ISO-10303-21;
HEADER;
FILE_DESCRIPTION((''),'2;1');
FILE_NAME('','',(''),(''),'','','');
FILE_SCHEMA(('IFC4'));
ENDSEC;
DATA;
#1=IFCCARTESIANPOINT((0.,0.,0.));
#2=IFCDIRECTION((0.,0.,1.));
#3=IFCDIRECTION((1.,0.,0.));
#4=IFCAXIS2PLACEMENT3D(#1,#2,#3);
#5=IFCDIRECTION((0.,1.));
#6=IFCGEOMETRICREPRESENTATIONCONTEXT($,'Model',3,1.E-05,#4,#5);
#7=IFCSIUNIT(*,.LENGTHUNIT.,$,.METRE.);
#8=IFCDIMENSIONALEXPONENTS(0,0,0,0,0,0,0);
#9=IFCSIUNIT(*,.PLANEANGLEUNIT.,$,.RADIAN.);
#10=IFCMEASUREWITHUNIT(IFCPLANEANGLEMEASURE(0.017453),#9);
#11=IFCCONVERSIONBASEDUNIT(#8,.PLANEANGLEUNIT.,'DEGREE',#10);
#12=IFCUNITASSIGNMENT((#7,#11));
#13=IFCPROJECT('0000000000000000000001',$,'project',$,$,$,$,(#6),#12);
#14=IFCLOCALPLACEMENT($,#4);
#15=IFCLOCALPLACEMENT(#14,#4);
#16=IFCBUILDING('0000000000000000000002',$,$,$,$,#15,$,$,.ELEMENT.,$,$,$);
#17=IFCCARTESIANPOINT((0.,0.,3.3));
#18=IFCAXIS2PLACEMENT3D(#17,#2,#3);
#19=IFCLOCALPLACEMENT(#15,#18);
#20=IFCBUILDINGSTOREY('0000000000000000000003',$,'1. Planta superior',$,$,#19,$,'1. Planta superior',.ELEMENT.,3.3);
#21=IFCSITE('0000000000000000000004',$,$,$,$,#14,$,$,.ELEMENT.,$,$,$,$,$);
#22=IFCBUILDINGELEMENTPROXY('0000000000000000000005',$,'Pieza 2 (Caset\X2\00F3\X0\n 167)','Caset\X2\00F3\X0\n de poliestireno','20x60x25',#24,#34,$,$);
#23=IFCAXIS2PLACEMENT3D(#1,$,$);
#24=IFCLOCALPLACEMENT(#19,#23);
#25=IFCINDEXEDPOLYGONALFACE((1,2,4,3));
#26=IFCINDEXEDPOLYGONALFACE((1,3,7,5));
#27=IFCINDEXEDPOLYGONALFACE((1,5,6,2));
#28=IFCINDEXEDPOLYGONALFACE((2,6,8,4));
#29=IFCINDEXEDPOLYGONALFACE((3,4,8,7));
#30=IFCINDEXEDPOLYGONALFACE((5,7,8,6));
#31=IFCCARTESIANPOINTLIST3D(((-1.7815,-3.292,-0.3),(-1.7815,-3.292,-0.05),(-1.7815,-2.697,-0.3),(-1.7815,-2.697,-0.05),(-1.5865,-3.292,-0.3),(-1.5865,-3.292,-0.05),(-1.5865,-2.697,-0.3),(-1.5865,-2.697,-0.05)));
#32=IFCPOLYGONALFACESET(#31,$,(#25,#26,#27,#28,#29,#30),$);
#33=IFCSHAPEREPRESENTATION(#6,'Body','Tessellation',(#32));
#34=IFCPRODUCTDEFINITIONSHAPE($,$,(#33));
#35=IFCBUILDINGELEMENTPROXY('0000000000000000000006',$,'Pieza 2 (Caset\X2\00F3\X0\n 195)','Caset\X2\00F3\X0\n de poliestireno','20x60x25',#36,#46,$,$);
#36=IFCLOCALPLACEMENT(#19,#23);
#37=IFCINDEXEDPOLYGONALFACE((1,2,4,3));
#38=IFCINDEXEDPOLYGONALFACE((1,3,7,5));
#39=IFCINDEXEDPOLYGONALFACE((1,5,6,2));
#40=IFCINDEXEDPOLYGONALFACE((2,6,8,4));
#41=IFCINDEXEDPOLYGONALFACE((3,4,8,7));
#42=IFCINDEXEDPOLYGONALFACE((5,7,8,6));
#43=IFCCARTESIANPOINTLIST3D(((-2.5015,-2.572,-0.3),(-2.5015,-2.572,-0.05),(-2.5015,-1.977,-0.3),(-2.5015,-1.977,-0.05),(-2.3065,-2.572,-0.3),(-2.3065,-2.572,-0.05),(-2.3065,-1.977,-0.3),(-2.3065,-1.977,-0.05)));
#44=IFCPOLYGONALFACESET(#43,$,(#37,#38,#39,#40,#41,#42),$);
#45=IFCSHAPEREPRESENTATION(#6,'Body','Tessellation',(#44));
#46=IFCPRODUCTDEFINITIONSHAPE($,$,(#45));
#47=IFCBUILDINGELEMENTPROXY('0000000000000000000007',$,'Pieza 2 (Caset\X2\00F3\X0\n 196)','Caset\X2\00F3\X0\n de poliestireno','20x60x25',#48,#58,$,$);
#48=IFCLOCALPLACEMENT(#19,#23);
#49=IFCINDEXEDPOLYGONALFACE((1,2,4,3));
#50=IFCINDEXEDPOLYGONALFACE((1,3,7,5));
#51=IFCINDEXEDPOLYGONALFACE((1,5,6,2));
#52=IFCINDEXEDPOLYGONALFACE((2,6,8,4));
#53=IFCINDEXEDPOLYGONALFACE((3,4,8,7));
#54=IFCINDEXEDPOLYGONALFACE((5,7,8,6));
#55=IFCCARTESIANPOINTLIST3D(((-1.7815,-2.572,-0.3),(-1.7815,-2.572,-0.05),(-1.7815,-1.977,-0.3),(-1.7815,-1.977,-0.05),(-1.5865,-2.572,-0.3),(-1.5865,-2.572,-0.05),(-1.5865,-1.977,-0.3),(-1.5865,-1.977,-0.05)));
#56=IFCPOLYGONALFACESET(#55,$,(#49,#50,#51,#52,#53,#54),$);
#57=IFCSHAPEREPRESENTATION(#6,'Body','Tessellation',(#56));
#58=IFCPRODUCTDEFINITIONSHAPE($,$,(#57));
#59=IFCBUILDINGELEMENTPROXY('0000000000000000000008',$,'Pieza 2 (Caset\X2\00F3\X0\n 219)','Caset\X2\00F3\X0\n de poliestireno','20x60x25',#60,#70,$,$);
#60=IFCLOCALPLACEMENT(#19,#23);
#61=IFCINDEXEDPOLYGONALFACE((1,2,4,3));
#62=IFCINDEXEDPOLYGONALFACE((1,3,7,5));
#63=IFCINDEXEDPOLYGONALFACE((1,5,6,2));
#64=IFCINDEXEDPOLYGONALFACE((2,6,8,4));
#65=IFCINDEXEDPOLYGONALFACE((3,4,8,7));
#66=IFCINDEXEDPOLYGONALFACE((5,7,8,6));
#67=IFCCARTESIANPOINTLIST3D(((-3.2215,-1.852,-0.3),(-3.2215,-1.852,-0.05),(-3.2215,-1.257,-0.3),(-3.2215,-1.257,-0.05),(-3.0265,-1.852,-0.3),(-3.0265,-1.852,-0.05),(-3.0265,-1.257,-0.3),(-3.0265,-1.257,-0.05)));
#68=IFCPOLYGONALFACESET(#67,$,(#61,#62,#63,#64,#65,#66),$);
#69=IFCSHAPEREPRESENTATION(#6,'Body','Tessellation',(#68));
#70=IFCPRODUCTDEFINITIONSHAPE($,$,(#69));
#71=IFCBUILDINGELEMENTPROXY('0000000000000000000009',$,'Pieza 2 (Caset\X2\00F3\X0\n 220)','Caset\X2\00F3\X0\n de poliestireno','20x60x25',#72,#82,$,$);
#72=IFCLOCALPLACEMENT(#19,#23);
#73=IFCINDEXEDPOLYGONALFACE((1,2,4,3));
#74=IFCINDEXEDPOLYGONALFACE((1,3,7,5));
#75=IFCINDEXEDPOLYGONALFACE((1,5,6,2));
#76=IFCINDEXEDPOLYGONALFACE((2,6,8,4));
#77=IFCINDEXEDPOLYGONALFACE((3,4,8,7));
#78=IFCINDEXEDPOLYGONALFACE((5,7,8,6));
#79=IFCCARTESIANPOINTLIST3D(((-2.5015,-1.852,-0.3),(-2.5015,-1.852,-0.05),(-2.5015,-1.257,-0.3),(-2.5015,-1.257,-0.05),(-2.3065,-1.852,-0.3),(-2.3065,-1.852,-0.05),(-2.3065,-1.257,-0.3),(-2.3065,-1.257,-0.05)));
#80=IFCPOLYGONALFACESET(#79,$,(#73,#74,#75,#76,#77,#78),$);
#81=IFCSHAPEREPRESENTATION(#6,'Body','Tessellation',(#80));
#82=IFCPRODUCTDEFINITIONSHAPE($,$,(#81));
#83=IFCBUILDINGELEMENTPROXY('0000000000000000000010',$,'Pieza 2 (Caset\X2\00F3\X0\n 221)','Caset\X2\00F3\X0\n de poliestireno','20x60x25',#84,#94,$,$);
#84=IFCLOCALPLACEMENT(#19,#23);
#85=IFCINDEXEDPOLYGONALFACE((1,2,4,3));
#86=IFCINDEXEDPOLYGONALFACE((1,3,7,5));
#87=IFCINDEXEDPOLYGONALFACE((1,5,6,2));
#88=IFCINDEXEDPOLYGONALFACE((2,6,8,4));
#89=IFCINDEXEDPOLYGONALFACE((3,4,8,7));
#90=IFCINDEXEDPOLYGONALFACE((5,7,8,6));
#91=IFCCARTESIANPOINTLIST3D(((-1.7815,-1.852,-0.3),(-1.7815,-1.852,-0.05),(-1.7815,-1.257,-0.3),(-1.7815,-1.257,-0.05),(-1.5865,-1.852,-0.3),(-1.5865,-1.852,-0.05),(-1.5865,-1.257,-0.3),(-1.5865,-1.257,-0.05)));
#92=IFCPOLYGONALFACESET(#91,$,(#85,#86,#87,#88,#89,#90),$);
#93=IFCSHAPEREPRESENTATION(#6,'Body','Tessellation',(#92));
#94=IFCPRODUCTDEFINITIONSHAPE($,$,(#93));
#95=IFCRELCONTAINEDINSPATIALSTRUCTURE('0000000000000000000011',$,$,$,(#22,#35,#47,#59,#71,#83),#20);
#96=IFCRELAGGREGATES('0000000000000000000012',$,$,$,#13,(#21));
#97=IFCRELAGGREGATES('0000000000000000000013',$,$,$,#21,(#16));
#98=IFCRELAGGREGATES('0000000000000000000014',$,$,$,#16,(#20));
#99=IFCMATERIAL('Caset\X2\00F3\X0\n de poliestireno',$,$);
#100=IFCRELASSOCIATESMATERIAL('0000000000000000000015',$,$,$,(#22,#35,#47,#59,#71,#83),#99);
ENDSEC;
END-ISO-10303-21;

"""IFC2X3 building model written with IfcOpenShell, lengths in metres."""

from ifc_helpers import new_model, entity, si_unit, converted_unit, direction, frame, origin_with_axes, origin_2d_with_axis, place, context, project, spatial, rectangle, extrude, source, transform, mapped, material, element, save


model = new_model("IFC2X3")

# Units and contexts
model_context = context("Model", 3, precision=1e-05, world=origin_with_axes(), true_north=direction((0.0, 1.0)))
ifc_project = project(units=[si_unit("LENGTHUNIT", "METRE"), converted_unit("PLANEANGLEUNIT", "DEGREE", entity("IfcPlaneAngleMeasure", 0.017453), si_unit("PLANEANGLEUNIT", "RADIAN"), dimensions=[0, 0, 0, 0, 0, 0, 0])], contexts=[model_context])

# Site, building, storey
site_placement = place(None, origin_with_axes())
site = spatial("IfcSite", under=ifc_project, at=site_placement, CompositionType="ELEMENT")
building_placement = place(site_placement, origin_with_axes())
building = spatial("IfcBuilding", under=site, at=building_placement, CompositionType="ELEMENT")
storey_placement = place(building_placement, frame((0.0, 0.0, 3.3), z_axis=(0.0, 0.0, 1.0), x_axis=(1.0, 0.0, 0.0)))
storey = spatial("IfcBuildingStorey", under=building, at=storey_placement, Name="1. Planta superior", LongName="1. Planta superior", CompositionType="ELEMENT", Elevation=3.3)

# Building element proxies
ifc_material = material(Name="Casetón de poliestireno")
shared_shape = source(origin_with_axes(), model_context, "Body", "SweptSolid", [
    extrude(rectangle(XDim=0.195, YDim=0.25, at=origin_2d_with_axis()), origin_with_axes(), (0.0, 0.0, 1.0), 0.595),
])
placement_1 = place(storey_placement, frame((-1.684, -3.292, -0.175), z_axis=(0.0, 1.0, 0.0), x_axis=(-1.0, 0.0, 0.0)))
for number, where, z_axis, x_axis, name in (
    (1, (0.0, 0.0, 0.0), (0.0, 0.0, 1.0), (1.0, 0.0, 0.0), "Pieza 2 (Casetón 167)"),
):
    element("IfcBuildingElementProxy", number, at=place(placement_1, frame(where, z_axis=z_axis, x_axis=x_axis)), inside=storey, material=ifc_material, Name=name, Description="Casetón de poliestireno", ObjectType="20x60x25", context=model_context, shape_type="MappedRepresentation", body=[
        mapped(shared_shape, transform((0.0, 0.0, 0.0), x_axis=(1.0, 0.0, 0.0), y_axis=(0.0, 1.0, 0.0), z_axis=(0.0, 0.0, 1.0))),
    ])
placement_2 = place(storey_placement, frame((-2.404, -2.572, -0.175), z_axis=(0.0, 1.0, 0.0), x_axis=(-1.0, 0.0, 0.0)))
for number, where, z_axis, x_axis, name in (
    (2, (0.0, 0.0, 0.0), (0.0, 0.0, 1.0), (1.0, 0.0, 0.0), "Pieza 2 (Casetón 195)"),
):
    element("IfcBuildingElementProxy", number, at=place(placement_2, frame(where, z_axis=z_axis, x_axis=x_axis)), inside=storey, material=ifc_material, Name=name, Description="Casetón de poliestireno", ObjectType="20x60x25", context=model_context, shape_type="MappedRepresentation", body=[
        mapped(shared_shape, transform((0.0, 0.0, 0.0), x_axis=(1.0, 0.0, 0.0), y_axis=(0.0, 1.0, 0.0), z_axis=(0.0, 0.0, 1.0))),
    ])
placement_3 = place(storey_placement, frame((-1.684, -2.572, -0.175), z_axis=(0.0, 1.0, 0.0), x_axis=(-1.0, 0.0, 0.0)))
for number, where, z_axis, x_axis, name in (
    (3, (0.0, 0.0, 0.0), (0.0, 0.0, 1.0), (1.0, 0.0, 0.0), "Pieza 2 (Casetón 196)"),
):
    element("IfcBuildingElementProxy", number, at=place(placement_3, frame(where, z_axis=z_axis, x_axis=x_axis)), inside=storey, material=ifc_material, Name=name, Description="Casetón de poliestireno", ObjectType="20x60x25", context=model_context, shape_type="MappedRepresentation", body=[
        mapped(shared_shape, transform((0.0, 0.0, 0.0), x_axis=(1.0, 0.0, 0.0), y_axis=(0.0, 1.0, 0.0), z_axis=(0.0, 0.0, 1.0))),
    ])
placement_4 = place(storey_placement, frame((-3.124, -1.852, -0.175), z_axis=(0.0, 1.0, 0.0), x_axis=(-1.0, 0.0, 0.0)))
for number, where, z_axis, x_axis, name in (
    (4, (0.0, 0.0, 0.0), (0.0, 0.0, 1.0), (1.0, 0.0, 0.0), "Pieza 2 (Casetón 219)"),
):
    element("IfcBuildingElementProxy", number, at=place(placement_4, frame(where, z_axis=z_axis, x_axis=x_axis)), inside=storey, material=ifc_material, Name=name, Description="Casetón de poliestireno", ObjectType="20x60x25", context=model_context, shape_type="MappedRepresentation", body=[
        mapped(shared_shape, transform((0.0, 0.0, 0.0), x_axis=(1.0, 0.0, 0.0), y_axis=(0.0, 1.0, 0.0), z_axis=(0.0, 0.0, 1.0))),
    ])
placement_5 = place(storey_placement, frame((-2.404, -1.852, -0.175), z_axis=(0.0, 1.0, 0.0), x_axis=(-1.0, 0.0, 0.0)))
for number, where, z_axis, x_axis, name in (
    (5, (0.0, 0.0, 0.0), (0.0, 0.0, 1.0), (1.0, 0.0, 0.0), "Pieza 2 (Casetón 220)"),
):
    element("IfcBuildingElementProxy", number, at=place(placement_5, frame(where, z_axis=z_axis, x_axis=x_axis)), inside=storey, material=ifc_material, Name=name, Description="Casetón de poliestireno", ObjectType="20x60x25", context=model_context, shape_type="MappedRepresentation", body=[
        mapped(shared_shape, transform((0.0, 0.0, 0.0), x_axis=(1.0, 0.0, 0.0), y_axis=(0.0, 1.0, 0.0), z_axis=(0.0, 0.0, 1.0))),
    ])
placement_6 = place(storey_placement, frame((-1.684, -1.852, -0.175), z_axis=(0.0, 1.0, 0.0), x_axis=(-1.0, 0.0, 0.0)))
for number, where, z_axis, x_axis, name in (
    (6, (0.0, 0.0, 0.0), (0.0, 0.0, 1.0), (1.0, 0.0, 0.0), "Pieza 2 (Casetón 221)"),
):
    element("IfcBuildingElementProxy", number, at=place(placement_6, frame(where, z_axis=z_axis, x_axis=x_axis)), inside=storey, material=ifc_material, Name=name, Description="Casetón de poliestireno", ObjectType="20x60x25", context=model_context, shape_type="MappedRepresentation", body=[
        mapped(shared_shape, transform((0.0, 0.0, 0.0), x_axis=(1.0, 0.0, 0.0), y_axis=(0.0, 1.0, 0.0), z_axis=(0.0, 0.0, 1.0))),
    ])

save(model, "model.ifc")
